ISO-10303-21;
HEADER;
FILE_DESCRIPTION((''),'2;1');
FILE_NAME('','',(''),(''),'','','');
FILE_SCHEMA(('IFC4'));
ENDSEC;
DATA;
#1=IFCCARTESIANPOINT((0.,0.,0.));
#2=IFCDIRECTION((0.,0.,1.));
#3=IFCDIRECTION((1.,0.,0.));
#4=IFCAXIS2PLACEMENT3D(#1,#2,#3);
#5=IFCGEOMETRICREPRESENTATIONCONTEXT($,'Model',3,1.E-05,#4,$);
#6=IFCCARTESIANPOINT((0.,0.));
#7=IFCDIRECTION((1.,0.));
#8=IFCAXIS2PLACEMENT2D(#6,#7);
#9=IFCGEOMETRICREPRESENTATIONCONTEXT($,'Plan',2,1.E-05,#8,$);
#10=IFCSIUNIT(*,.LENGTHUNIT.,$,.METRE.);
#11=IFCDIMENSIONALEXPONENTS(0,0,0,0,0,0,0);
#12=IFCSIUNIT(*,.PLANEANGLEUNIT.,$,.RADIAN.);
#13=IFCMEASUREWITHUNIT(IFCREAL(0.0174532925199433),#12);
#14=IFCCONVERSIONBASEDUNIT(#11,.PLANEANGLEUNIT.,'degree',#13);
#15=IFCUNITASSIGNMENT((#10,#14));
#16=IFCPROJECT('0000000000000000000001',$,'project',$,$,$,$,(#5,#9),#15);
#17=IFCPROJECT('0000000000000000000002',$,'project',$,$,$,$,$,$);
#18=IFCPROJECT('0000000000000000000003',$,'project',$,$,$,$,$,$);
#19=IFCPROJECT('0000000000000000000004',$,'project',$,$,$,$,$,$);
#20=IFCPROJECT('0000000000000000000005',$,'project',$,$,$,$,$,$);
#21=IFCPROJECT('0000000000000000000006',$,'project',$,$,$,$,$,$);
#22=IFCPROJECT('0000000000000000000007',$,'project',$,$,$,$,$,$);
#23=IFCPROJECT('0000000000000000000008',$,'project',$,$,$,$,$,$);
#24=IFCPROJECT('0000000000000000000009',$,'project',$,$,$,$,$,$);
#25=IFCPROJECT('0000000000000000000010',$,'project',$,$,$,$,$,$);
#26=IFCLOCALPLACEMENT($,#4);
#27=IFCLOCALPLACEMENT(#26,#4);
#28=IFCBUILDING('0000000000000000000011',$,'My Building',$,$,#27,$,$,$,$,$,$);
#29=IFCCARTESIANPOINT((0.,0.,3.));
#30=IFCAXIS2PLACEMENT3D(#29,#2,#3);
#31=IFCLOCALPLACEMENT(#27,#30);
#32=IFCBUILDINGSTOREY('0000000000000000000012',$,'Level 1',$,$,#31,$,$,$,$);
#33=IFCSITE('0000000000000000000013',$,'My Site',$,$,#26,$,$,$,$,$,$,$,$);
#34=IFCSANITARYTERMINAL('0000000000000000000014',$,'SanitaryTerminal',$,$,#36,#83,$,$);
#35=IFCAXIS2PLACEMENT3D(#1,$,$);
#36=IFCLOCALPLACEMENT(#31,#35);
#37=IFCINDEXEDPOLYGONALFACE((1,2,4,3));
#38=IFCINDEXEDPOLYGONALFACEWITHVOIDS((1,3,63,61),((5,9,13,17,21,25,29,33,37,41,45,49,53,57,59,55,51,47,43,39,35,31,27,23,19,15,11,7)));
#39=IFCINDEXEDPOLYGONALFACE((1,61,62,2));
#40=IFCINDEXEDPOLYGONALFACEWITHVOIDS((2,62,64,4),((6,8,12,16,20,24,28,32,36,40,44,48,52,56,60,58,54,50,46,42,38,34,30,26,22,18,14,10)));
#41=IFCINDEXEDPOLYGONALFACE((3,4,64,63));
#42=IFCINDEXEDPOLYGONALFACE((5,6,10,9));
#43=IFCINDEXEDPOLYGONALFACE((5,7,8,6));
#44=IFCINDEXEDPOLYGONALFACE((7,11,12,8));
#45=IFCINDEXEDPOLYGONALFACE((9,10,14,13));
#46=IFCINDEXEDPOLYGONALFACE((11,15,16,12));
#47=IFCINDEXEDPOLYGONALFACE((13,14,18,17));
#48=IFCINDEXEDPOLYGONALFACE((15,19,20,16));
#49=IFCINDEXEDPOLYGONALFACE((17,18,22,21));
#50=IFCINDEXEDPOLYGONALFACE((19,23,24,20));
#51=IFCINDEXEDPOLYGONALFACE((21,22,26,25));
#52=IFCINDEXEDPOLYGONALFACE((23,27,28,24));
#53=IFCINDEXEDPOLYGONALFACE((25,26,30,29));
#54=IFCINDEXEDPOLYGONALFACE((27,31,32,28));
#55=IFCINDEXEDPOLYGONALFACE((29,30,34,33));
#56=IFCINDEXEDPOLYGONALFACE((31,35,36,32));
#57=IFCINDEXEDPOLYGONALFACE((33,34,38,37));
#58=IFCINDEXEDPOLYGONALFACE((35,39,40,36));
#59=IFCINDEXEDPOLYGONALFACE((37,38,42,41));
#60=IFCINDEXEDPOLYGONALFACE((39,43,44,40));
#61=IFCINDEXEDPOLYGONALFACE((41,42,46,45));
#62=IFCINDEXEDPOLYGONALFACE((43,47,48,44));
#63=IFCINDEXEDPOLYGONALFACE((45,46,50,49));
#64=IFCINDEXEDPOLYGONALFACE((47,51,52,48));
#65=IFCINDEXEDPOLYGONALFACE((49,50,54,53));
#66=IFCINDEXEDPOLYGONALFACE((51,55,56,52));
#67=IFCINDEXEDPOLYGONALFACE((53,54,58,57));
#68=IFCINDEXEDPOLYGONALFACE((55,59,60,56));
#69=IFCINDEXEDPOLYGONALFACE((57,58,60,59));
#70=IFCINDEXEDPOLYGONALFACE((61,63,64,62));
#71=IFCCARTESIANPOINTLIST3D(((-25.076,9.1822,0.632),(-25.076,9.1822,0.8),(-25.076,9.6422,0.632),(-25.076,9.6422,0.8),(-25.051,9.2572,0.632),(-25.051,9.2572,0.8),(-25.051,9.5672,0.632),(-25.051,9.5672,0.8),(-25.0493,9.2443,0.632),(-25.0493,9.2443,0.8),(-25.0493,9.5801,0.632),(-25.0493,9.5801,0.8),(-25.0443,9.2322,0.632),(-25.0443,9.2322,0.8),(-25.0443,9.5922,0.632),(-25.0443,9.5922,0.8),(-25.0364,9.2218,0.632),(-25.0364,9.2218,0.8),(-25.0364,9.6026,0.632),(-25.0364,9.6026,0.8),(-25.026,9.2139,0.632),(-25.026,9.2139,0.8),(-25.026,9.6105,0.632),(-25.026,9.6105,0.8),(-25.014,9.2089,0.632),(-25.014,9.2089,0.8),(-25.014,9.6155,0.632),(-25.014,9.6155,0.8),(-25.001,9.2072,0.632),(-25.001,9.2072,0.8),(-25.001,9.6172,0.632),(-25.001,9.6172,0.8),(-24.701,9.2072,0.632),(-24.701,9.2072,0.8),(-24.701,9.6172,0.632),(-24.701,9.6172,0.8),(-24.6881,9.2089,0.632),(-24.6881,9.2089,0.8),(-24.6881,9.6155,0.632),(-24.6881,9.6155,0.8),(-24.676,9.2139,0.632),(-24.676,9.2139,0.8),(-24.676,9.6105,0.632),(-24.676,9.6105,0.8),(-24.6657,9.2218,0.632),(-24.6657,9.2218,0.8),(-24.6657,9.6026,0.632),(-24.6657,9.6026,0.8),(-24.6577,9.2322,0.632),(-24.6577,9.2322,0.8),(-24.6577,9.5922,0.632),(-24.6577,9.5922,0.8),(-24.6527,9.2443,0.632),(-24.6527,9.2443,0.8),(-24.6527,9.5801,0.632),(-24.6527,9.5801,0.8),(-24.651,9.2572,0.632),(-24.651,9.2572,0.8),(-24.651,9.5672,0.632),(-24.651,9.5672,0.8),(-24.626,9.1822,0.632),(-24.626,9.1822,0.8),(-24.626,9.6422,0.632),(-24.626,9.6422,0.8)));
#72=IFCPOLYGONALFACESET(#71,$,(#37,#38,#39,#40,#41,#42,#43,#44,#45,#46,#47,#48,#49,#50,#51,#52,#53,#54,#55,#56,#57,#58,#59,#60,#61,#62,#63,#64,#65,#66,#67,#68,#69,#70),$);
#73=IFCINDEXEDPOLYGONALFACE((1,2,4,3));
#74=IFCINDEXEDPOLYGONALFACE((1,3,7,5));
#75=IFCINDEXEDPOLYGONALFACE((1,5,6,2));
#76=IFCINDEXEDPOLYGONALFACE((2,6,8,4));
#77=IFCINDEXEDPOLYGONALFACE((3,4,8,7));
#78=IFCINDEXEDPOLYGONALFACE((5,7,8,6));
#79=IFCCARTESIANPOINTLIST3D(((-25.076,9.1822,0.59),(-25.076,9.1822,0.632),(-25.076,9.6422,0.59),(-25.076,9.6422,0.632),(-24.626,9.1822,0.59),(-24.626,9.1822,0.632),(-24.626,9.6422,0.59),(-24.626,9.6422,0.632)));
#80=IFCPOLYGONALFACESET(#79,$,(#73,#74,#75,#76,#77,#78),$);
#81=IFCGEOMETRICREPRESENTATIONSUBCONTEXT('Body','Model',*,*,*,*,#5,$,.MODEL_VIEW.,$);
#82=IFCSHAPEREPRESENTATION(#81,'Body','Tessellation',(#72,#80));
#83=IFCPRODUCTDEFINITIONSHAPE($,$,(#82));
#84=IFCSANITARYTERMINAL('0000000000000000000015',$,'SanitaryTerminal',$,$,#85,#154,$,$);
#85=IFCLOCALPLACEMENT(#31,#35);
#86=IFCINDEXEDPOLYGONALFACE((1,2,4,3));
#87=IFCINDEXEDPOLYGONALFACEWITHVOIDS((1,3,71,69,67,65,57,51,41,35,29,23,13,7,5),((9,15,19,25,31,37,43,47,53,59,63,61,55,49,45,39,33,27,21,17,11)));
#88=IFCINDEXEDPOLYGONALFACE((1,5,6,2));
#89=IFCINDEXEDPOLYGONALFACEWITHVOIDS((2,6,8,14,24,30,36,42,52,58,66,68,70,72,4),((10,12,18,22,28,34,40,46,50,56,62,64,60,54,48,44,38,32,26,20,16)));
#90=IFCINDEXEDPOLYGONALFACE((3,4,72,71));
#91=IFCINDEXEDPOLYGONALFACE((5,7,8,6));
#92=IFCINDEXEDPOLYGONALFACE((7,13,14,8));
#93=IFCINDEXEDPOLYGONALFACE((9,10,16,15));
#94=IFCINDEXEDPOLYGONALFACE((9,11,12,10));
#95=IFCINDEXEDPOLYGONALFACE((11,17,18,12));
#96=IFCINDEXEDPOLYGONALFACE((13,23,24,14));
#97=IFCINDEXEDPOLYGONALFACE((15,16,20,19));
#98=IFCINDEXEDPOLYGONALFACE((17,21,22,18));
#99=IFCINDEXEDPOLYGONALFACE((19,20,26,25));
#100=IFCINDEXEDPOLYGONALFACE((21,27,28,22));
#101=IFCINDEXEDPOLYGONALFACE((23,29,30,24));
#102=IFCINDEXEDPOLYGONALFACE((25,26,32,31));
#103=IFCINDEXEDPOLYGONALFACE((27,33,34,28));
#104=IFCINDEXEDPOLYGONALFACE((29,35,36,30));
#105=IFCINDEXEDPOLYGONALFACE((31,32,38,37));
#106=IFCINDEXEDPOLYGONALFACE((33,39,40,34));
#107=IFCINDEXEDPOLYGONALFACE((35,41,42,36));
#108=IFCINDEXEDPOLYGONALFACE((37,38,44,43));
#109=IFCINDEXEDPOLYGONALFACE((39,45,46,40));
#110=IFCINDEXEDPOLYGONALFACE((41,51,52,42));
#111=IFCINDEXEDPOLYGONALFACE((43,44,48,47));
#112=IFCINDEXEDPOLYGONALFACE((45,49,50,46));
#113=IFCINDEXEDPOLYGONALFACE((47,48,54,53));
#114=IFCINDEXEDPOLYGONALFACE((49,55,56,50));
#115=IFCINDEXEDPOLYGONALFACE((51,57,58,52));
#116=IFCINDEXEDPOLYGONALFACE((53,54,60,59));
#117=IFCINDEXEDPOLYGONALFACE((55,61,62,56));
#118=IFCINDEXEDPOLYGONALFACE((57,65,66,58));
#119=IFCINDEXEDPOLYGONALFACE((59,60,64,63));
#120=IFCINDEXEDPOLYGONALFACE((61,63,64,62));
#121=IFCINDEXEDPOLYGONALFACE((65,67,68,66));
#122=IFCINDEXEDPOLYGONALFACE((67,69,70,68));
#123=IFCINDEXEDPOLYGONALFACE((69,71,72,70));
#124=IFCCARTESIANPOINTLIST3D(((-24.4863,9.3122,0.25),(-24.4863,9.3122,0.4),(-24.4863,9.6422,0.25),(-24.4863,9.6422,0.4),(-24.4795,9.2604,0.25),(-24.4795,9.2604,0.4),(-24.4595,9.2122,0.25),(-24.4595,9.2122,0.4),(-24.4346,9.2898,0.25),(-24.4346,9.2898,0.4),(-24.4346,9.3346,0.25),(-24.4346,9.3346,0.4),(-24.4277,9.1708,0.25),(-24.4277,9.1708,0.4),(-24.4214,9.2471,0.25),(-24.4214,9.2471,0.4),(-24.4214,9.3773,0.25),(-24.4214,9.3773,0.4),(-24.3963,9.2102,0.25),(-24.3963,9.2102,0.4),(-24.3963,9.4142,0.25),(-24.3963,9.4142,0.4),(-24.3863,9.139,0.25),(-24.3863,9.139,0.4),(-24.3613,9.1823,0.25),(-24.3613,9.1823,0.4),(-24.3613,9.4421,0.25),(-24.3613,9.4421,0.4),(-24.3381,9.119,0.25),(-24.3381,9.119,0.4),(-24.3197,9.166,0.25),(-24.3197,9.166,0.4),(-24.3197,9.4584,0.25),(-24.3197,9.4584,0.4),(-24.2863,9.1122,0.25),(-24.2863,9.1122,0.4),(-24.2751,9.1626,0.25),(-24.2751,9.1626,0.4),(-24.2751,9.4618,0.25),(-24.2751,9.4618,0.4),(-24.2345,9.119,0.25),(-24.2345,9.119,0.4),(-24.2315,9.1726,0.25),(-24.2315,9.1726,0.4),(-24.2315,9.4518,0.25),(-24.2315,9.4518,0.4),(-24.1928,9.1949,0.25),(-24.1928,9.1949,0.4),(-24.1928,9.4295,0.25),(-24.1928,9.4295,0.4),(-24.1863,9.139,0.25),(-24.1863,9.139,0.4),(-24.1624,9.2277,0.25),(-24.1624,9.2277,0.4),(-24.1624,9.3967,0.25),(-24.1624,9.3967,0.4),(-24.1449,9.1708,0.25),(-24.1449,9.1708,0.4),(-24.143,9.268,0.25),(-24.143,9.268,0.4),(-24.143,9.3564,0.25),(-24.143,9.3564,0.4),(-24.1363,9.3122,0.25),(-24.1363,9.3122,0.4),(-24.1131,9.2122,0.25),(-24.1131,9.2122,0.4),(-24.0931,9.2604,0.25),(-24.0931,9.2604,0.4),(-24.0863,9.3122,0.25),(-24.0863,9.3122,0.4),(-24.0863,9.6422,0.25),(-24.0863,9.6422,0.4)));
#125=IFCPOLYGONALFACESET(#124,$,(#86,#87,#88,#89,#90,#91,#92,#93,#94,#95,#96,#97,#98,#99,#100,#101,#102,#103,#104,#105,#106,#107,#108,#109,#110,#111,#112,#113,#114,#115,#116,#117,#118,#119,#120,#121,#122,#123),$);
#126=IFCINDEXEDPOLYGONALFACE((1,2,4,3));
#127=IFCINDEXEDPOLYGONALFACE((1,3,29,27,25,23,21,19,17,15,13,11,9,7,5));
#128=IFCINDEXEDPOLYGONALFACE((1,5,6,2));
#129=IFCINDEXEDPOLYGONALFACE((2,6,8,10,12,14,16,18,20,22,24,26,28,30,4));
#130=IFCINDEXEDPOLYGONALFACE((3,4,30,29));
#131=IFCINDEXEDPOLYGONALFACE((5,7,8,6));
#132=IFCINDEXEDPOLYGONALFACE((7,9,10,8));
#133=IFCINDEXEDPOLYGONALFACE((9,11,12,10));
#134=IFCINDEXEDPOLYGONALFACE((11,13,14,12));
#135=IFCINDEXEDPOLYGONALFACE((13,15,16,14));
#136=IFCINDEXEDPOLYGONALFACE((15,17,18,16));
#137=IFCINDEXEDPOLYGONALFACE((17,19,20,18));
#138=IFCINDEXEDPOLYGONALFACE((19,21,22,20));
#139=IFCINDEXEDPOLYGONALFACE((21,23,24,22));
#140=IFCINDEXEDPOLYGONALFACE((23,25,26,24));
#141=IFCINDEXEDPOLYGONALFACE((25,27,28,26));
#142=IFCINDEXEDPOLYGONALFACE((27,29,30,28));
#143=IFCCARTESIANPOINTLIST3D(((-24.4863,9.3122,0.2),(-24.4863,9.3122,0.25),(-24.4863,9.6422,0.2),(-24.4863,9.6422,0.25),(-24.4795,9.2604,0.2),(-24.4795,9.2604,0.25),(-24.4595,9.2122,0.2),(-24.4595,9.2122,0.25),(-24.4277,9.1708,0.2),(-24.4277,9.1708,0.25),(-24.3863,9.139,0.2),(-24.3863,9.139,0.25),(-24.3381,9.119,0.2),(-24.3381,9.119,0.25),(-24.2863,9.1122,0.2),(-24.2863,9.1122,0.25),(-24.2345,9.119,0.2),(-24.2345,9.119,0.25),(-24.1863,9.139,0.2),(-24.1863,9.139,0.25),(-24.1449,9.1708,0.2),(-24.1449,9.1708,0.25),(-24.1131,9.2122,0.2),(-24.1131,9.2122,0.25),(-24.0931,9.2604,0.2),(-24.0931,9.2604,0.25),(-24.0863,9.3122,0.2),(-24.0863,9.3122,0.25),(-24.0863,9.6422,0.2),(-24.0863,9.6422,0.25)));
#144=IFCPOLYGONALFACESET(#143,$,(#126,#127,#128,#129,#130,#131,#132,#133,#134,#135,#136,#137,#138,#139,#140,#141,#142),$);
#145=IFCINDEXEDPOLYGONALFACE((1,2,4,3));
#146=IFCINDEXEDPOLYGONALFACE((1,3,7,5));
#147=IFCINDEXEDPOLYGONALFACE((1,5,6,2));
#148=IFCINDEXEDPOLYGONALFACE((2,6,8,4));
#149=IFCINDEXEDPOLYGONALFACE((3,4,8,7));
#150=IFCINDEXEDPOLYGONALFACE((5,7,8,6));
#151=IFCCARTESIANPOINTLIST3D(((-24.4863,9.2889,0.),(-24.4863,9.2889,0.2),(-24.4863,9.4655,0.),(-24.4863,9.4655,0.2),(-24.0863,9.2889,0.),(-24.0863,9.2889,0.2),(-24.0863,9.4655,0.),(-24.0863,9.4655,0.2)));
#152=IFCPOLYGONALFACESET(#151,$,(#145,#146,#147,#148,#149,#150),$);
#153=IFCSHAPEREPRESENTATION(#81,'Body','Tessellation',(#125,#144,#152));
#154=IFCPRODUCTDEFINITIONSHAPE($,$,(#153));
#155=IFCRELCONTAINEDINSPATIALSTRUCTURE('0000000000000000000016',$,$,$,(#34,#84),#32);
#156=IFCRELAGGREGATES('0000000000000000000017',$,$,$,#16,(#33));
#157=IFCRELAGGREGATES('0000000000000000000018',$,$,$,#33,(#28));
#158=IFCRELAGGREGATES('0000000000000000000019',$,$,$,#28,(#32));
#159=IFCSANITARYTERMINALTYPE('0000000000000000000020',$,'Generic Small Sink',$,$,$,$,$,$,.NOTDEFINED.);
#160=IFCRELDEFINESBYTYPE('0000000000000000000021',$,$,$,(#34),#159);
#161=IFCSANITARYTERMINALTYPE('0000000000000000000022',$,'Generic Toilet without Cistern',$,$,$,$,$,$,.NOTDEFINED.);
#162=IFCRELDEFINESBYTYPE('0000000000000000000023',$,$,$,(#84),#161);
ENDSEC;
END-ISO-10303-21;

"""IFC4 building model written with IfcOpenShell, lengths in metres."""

from ifc_helpers import new_model, entity, si_unit, converted_unit, frame, frame_2d, origin_with_axes, origin_2d_with_axis, place, context, subcontext, project, spatial, line, arc, indexed_curve, circle_curve, outline, extrude, shape, source, transform, mapped, type_object, type_shapes, element, save


model = new_model("IFC4")

# Units and contexts
model_context = context("Model", 3, precision=1e-05, world=origin_with_axes())
plan_context = context("Plan", 2, precision=1e-05, world=origin_2d_with_axis())
body_context_1 = subcontext(model_context, "Body", "Model", "MODEL_VIEW")
body_context_2 = subcontext(plan_context, "Body", "Plan", "PLAN_VIEW")
ifc_project_1 = project(units=[si_unit("LENGTHUNIT", "METRE"), converted_unit("PLANEANGLEUNIT", "degree", entity("IfcReal", 0.0174532925199433), si_unit("PLANEANGLEUNIT", "RADIAN"), dimensions=[0, 0, 0, 0, 0, 0, 0])], contexts=[model_context, plan_context])
ifc_project_2 = project()
ifc_project_3 = project()
ifc_project_4 = project()
ifc_project_5 = project()
ifc_project_6 = project()
ifc_project_7 = project()
ifc_project_8 = project()
ifc_project_9 = project()
ifc_project_10 = project()

# Site, building, storey
site_placement = place(None, origin_with_axes())
site = spatial("IfcSite", under=ifc_project_1, at=site_placement, Name="My Site")
building_placement = place(site_placement, origin_with_axes())
building = spatial("IfcBuilding", under=site, at=building_placement, Name="My Building")
storey_placement = place(building_placement, frame((0.0, 0.0, 3.0), z_axis=(0.0, 0.0, 1.0), x_axis=(1.0, 0.0, 0.0)))
storey = spatial("IfcBuildingStorey", under=building, at=storey_placement, Name="Level 1")

# Sanitary terminals
sanitary_terminal_type_1 = type_object("IfcSanitaryTerminalType", Name="Generic Small Sink", PredefinedType="NOTDEFINED")
shared_indexed_poly_curve = entity("IfcIndexedPolyCurve", entity("IfcCartesianPointList2D", [[0.0, 0.0], [0.45, 0.0], [0.45, 0.46], [0.0, 0.46]]), [entity("IfcLineIndex", [1, 2]), entity("IfcLineIndex", [2, 3]), entity("IfcLineIndex", [3, 4]), entity("IfcLineIndex", [4, 1])])
shared_shape_1 = source(origin_with_axes(), body_context_1, "Body", "SweptSolid", [
    entity("IfcExtrudedAreaSolid", entity("IfcArbitraryProfileDefWithVoids", "AREA", None, shared_indexed_poly_curve, [entity("IfcIndexedPolyCurve", entity("IfcCartesianPointList2D", [[0.025, 0.075], [0.0396, 0.0396], [0.075, 0.025], [0.375, 0.025], [0.4104, 0.0396], [0.425, 0.075], [0.425, 0.385], [0.4104, 0.4204], [0.375, 0.435], [0.075, 0.435], [0.0396, 0.4204], [0.025, 0.385]]), [entity("IfcLineIndex", [12, 1]), entity("IfcArcIndex", [1, 2, 3]), entity("IfcLineIndex", [3, 4]), entity("IfcArcIndex", [4, 5, 6]), entity("IfcLineIndex", [6, 7]), entity("IfcArcIndex", [7, 8, 9]), entity("IfcLineIndex", [9, 10]), entity("IfcArcIndex", [10, 11, 12]), entity("IfcLineIndex", [12, 1])])]), entity("IfcAxis2Placement3D", entity("IfcCartesianPoint", [-0.225, -0.46, 0.042]), entity("IfcDirection", [0.0, 0.0, 1.0]), entity("IfcDirection", [1.0, 0.0, 0.0])), entity("IfcDirection", [0.0, 0.0, 1.0]), 0.168),
    entity("IfcExtrudedAreaSolid", entity("IfcArbitraryClosedProfileDef", "AREA", None, shared_indexed_poly_curve), entity("IfcAxis2Placement3D", entity("IfcCartesianPoint", [-0.225, -0.46, 0.0]), entity("IfcDirection", [0.0, 0.0, 1.0]), entity("IfcDirection", [1.0, 0.0, 0.0])), entity("IfcDirection", [0.0, 0.0, 1.0]), 0.042),
])
shared_shape_2 = source(origin_with_axes(), body_context_2, "Body", "Curve2D", [
    entity("IfcIndexedPolyCurve", entity("IfcCartesianPointList2D", [[-0.225, -0.46], [0.225, -0.46], [0.225, 0.0], [-0.225, 0.0]]), [entity("IfcLineIndex", [1, 2]), entity("IfcLineIndex", [2, 3]), entity("IfcLineIndex", [3, 4]), entity("IfcLineIndex", [4, 1])]),
    entity("IfcIndexedPolyCurve", entity("IfcCartesianPointList2D", [[-0.2, -0.385], [-0.1854, -0.4204], [-0.15, -0.435], [0.15, -0.435], [0.1854, -0.4204], [0.2, -0.385], [0.2, -0.075], [0.1854, -0.0396], [0.15, -0.025], [-0.15, -0.025], [-0.1854, -0.0396], [-0.2, -0.075]]), [entity("IfcLineIndex", [12, 1]), entity("IfcArcIndex", [1, 2, 3]), entity("IfcLineIndex", [3, 4]), entity("IfcArcIndex", [4, 5, 6]), entity("IfcLineIndex", [6, 7]), entity("IfcArcIndex", [7, 8, 9]), entity("IfcLineIndex", [9, 10]), entity("IfcArcIndex", [10, 11, 12]), entity("IfcLineIndex", [12, 1])]),
    entity("IfcCircle", entity("IfcAxis2Placement2D", entity("IfcCartesianPoint", [0.0, -0.125])), 0.025),
    entity("IfcIndexedPolyCurve", entity("IfcCartesianPointList2D", [[0.0, -0.0125], [0.0, -0.1325]]), [entity("IfcLineIndex", [1, 2])]),
])
type_shapes(sanitary_terminal_type_1, [shared_shape_1, shared_shape_2])
sanitary_terminal_1_placement = place(storey_placement, frame((-24.851, 9.6422, 0.59), z_axis=(0.0, 0.0, 1.0), x_axis=(1.0, 0.0, 0.0)))
element("IfcSanitaryTerminal", 1, at=sanitary_terminal_1_placement, inside=storey, type_object=sanitary_terminal_type_1, Name="SanitaryTerminal", shapes=[
    shape(body_context_1, "Body", "MappedRepresentation", [mapped(shared_shape_1, transform((0.0, 0.0, 0.0), x_axis=(1.0, 0.0, 0.0), y_axis=(0.0, 1.0, 0.0), z_axis=(0.0, 0.0, 1.0), scale=1.0))]),
    shape(body_context_2, "Body", "MappedRepresentation", [mapped(shared_shape_2, transform((0.0, 0.0, 0.0), x_axis=(1.0, 0.0, 0.0), y_axis=(0.0, 1.0, 0.0), z_axis=(0.0, 0.0, 1.0), scale=1.0))]),
])
sanitary_terminal_type_2 = type_object("IfcSanitaryTerminalType", Name="Generic Toilet without Cistern", PredefinedType="NOTDEFINED")
shared_shape_3 = source(origin_with_axes(), body_context_1, "Body", "SweptSolid", [
    extrude(outline(indexed_curve([(-0.2, 0.0), (0.2, 0.0), (0.2, -0.33), (0.1414, -0.4714), (0.0, -0.53), (-0.1414, -0.4714), (-0.2, -0.33)], segments=[line(1, 2), line(2, 3), arc(3, 4, 5), arc(5, 6, 7), line(7, 1)]), holes=[circle_curve(frame_2d((0.0, -0.33)), 0.15)]), frame((0.0, 0.0, 0.25), z_axis=(0.0, 0.0, 1.0), x_axis=(1.0, 0.0, 0.0)), (0.0, 0.0, 1.0), 0.15),
    extrude(outline(indexed_curve([(-0.2, 0.0), (0.2, 0.0), (0.2, -0.33), (0.1414, -0.4714), (0.0, -0.53), (-0.1414, -0.4714), (-0.2, -0.33)], segments=[line(1, 2), line(2, 3), arc(3, 4, 5), arc(5, 6, 7), line(7, 1)])), frame((0.0, 0.0, 0.2), z_axis=(0.0, 0.0, 1.0), x_axis=(1.0, 0.0, 0.0)), (0.0, 0.0, 1.0), 0.05),
    extrude(outline(indexed_curve([(-0.2, -0.1767), (0.2, -0.1767), (0.2, -0.3533), (-0.2, -0.3533)], segments=[line(1, 2), line(2, 3), line(3, 4), line(4, 1)])), origin_with_axes(), (0.0, 0.0, 1.0), 0.2),
])
shared_shape_4 = source(origin_with_axes(), body_context_2, "Body", "Curve2D", [
    entity("IfcIndexedPolyCurve", entity("IfcCartesianPointList2D", [[-0.12, 0.0], [0.12, 0.0]]), [entity("IfcLineIndex", [1, 2])]),
    entity("IfcIndexedPolyCurve", entity("IfcCartesianPointList2D", [[0.12, 0.0], [0.2, -0.159]]), [entity("IfcLineIndex", [1, 2])]),
    entity("IfcTrimmedCurve", entity("IfcEllipse", entity("IfcAxis2Placement2D", entity("IfcCartesianPoint", [0.0, -0.159]), entity("IfcDirection", [1.0, 0.0])), 0.2, 0.371), [entity("IfcCartesianPoint", [-0.2, -0.159])], [entity("IfcCartesianPoint", [0.2, -0.159])], True, "CARTESIAN"),
    entity("IfcIndexedPolyCurve", entity("IfcCartesianPointList2D", [[-0.12, 0.0], [-0.2, -0.159]]), [entity("IfcLineIndex", [1, 2])]),
    entity("IfcEllipse", entity("IfcAxis2Placement2D", entity("IfcCartesianPoint", [0.0, -0.2968]), entity("IfcDirection", [1.0, 0.0])), 0.15, 0.1855),
    entity("IfcIndexedPolyCurve", entity("IfcCartesianPointList2D", [[-0.025, -0.2968], [-0.025, -0.2703], [0.025, -0.2703], [0.025, -0.2968]]), [entity("IfcLineIndex", [1, 2]), entity("IfcLineIndex", [2, 3]), entity("IfcLineIndex", [3, 4])]),
    entity("IfcTrimmedCurve", entity("IfcEllipse", entity("IfcAxis2Placement2D", entity("IfcCartesianPoint", [0.0, -0.2968]), entity("IfcDirection", [1.0, 0.0])), 0.025, 0.0265), [entity("IfcCartesianPoint", [-0.025, -0.2968])], [entity("IfcCartesianPoint", [0.025, -0.2968])], True, "CARTESIAN"),
])
type_shapes(sanitary_terminal_type_2, [shared_shape_3, shared_shape_4])
sanitary_terminal_2_placement = place(storey_placement, frame((-24.2863, 9.6422, 0.0), z_axis=(0.0, 0.0, 1.0), x_axis=(1.0, 0.0, 0.0)))
element("IfcSanitaryTerminal", 2, at=sanitary_terminal_2_placement, inside=storey, type_object=sanitary_terminal_type_2, Name="SanitaryTerminal", shapes=[
    shape(body_context_1, "Body", "MappedRepresentation", [mapped(shared_shape_3, transform((0.0, 0.0, 0.0), x_axis=(1.0, 0.0, 0.0), y_axis=(0.0, 1.0, 0.0), z_axis=(0.0, 0.0, 1.0), scale=1.0))]),
    shape(body_context_2, "Body", "MappedRepresentation", [mapped(shared_shape_4, transform((0.0, 0.0, 0.0), x_axis=(1.0, 0.0, 0.0), y_axis=(0.0, 1.0, 0.0), z_axis=(0.0, 0.0, 1.0), scale=1.0))]),
])

save(model, "model.ifc")
